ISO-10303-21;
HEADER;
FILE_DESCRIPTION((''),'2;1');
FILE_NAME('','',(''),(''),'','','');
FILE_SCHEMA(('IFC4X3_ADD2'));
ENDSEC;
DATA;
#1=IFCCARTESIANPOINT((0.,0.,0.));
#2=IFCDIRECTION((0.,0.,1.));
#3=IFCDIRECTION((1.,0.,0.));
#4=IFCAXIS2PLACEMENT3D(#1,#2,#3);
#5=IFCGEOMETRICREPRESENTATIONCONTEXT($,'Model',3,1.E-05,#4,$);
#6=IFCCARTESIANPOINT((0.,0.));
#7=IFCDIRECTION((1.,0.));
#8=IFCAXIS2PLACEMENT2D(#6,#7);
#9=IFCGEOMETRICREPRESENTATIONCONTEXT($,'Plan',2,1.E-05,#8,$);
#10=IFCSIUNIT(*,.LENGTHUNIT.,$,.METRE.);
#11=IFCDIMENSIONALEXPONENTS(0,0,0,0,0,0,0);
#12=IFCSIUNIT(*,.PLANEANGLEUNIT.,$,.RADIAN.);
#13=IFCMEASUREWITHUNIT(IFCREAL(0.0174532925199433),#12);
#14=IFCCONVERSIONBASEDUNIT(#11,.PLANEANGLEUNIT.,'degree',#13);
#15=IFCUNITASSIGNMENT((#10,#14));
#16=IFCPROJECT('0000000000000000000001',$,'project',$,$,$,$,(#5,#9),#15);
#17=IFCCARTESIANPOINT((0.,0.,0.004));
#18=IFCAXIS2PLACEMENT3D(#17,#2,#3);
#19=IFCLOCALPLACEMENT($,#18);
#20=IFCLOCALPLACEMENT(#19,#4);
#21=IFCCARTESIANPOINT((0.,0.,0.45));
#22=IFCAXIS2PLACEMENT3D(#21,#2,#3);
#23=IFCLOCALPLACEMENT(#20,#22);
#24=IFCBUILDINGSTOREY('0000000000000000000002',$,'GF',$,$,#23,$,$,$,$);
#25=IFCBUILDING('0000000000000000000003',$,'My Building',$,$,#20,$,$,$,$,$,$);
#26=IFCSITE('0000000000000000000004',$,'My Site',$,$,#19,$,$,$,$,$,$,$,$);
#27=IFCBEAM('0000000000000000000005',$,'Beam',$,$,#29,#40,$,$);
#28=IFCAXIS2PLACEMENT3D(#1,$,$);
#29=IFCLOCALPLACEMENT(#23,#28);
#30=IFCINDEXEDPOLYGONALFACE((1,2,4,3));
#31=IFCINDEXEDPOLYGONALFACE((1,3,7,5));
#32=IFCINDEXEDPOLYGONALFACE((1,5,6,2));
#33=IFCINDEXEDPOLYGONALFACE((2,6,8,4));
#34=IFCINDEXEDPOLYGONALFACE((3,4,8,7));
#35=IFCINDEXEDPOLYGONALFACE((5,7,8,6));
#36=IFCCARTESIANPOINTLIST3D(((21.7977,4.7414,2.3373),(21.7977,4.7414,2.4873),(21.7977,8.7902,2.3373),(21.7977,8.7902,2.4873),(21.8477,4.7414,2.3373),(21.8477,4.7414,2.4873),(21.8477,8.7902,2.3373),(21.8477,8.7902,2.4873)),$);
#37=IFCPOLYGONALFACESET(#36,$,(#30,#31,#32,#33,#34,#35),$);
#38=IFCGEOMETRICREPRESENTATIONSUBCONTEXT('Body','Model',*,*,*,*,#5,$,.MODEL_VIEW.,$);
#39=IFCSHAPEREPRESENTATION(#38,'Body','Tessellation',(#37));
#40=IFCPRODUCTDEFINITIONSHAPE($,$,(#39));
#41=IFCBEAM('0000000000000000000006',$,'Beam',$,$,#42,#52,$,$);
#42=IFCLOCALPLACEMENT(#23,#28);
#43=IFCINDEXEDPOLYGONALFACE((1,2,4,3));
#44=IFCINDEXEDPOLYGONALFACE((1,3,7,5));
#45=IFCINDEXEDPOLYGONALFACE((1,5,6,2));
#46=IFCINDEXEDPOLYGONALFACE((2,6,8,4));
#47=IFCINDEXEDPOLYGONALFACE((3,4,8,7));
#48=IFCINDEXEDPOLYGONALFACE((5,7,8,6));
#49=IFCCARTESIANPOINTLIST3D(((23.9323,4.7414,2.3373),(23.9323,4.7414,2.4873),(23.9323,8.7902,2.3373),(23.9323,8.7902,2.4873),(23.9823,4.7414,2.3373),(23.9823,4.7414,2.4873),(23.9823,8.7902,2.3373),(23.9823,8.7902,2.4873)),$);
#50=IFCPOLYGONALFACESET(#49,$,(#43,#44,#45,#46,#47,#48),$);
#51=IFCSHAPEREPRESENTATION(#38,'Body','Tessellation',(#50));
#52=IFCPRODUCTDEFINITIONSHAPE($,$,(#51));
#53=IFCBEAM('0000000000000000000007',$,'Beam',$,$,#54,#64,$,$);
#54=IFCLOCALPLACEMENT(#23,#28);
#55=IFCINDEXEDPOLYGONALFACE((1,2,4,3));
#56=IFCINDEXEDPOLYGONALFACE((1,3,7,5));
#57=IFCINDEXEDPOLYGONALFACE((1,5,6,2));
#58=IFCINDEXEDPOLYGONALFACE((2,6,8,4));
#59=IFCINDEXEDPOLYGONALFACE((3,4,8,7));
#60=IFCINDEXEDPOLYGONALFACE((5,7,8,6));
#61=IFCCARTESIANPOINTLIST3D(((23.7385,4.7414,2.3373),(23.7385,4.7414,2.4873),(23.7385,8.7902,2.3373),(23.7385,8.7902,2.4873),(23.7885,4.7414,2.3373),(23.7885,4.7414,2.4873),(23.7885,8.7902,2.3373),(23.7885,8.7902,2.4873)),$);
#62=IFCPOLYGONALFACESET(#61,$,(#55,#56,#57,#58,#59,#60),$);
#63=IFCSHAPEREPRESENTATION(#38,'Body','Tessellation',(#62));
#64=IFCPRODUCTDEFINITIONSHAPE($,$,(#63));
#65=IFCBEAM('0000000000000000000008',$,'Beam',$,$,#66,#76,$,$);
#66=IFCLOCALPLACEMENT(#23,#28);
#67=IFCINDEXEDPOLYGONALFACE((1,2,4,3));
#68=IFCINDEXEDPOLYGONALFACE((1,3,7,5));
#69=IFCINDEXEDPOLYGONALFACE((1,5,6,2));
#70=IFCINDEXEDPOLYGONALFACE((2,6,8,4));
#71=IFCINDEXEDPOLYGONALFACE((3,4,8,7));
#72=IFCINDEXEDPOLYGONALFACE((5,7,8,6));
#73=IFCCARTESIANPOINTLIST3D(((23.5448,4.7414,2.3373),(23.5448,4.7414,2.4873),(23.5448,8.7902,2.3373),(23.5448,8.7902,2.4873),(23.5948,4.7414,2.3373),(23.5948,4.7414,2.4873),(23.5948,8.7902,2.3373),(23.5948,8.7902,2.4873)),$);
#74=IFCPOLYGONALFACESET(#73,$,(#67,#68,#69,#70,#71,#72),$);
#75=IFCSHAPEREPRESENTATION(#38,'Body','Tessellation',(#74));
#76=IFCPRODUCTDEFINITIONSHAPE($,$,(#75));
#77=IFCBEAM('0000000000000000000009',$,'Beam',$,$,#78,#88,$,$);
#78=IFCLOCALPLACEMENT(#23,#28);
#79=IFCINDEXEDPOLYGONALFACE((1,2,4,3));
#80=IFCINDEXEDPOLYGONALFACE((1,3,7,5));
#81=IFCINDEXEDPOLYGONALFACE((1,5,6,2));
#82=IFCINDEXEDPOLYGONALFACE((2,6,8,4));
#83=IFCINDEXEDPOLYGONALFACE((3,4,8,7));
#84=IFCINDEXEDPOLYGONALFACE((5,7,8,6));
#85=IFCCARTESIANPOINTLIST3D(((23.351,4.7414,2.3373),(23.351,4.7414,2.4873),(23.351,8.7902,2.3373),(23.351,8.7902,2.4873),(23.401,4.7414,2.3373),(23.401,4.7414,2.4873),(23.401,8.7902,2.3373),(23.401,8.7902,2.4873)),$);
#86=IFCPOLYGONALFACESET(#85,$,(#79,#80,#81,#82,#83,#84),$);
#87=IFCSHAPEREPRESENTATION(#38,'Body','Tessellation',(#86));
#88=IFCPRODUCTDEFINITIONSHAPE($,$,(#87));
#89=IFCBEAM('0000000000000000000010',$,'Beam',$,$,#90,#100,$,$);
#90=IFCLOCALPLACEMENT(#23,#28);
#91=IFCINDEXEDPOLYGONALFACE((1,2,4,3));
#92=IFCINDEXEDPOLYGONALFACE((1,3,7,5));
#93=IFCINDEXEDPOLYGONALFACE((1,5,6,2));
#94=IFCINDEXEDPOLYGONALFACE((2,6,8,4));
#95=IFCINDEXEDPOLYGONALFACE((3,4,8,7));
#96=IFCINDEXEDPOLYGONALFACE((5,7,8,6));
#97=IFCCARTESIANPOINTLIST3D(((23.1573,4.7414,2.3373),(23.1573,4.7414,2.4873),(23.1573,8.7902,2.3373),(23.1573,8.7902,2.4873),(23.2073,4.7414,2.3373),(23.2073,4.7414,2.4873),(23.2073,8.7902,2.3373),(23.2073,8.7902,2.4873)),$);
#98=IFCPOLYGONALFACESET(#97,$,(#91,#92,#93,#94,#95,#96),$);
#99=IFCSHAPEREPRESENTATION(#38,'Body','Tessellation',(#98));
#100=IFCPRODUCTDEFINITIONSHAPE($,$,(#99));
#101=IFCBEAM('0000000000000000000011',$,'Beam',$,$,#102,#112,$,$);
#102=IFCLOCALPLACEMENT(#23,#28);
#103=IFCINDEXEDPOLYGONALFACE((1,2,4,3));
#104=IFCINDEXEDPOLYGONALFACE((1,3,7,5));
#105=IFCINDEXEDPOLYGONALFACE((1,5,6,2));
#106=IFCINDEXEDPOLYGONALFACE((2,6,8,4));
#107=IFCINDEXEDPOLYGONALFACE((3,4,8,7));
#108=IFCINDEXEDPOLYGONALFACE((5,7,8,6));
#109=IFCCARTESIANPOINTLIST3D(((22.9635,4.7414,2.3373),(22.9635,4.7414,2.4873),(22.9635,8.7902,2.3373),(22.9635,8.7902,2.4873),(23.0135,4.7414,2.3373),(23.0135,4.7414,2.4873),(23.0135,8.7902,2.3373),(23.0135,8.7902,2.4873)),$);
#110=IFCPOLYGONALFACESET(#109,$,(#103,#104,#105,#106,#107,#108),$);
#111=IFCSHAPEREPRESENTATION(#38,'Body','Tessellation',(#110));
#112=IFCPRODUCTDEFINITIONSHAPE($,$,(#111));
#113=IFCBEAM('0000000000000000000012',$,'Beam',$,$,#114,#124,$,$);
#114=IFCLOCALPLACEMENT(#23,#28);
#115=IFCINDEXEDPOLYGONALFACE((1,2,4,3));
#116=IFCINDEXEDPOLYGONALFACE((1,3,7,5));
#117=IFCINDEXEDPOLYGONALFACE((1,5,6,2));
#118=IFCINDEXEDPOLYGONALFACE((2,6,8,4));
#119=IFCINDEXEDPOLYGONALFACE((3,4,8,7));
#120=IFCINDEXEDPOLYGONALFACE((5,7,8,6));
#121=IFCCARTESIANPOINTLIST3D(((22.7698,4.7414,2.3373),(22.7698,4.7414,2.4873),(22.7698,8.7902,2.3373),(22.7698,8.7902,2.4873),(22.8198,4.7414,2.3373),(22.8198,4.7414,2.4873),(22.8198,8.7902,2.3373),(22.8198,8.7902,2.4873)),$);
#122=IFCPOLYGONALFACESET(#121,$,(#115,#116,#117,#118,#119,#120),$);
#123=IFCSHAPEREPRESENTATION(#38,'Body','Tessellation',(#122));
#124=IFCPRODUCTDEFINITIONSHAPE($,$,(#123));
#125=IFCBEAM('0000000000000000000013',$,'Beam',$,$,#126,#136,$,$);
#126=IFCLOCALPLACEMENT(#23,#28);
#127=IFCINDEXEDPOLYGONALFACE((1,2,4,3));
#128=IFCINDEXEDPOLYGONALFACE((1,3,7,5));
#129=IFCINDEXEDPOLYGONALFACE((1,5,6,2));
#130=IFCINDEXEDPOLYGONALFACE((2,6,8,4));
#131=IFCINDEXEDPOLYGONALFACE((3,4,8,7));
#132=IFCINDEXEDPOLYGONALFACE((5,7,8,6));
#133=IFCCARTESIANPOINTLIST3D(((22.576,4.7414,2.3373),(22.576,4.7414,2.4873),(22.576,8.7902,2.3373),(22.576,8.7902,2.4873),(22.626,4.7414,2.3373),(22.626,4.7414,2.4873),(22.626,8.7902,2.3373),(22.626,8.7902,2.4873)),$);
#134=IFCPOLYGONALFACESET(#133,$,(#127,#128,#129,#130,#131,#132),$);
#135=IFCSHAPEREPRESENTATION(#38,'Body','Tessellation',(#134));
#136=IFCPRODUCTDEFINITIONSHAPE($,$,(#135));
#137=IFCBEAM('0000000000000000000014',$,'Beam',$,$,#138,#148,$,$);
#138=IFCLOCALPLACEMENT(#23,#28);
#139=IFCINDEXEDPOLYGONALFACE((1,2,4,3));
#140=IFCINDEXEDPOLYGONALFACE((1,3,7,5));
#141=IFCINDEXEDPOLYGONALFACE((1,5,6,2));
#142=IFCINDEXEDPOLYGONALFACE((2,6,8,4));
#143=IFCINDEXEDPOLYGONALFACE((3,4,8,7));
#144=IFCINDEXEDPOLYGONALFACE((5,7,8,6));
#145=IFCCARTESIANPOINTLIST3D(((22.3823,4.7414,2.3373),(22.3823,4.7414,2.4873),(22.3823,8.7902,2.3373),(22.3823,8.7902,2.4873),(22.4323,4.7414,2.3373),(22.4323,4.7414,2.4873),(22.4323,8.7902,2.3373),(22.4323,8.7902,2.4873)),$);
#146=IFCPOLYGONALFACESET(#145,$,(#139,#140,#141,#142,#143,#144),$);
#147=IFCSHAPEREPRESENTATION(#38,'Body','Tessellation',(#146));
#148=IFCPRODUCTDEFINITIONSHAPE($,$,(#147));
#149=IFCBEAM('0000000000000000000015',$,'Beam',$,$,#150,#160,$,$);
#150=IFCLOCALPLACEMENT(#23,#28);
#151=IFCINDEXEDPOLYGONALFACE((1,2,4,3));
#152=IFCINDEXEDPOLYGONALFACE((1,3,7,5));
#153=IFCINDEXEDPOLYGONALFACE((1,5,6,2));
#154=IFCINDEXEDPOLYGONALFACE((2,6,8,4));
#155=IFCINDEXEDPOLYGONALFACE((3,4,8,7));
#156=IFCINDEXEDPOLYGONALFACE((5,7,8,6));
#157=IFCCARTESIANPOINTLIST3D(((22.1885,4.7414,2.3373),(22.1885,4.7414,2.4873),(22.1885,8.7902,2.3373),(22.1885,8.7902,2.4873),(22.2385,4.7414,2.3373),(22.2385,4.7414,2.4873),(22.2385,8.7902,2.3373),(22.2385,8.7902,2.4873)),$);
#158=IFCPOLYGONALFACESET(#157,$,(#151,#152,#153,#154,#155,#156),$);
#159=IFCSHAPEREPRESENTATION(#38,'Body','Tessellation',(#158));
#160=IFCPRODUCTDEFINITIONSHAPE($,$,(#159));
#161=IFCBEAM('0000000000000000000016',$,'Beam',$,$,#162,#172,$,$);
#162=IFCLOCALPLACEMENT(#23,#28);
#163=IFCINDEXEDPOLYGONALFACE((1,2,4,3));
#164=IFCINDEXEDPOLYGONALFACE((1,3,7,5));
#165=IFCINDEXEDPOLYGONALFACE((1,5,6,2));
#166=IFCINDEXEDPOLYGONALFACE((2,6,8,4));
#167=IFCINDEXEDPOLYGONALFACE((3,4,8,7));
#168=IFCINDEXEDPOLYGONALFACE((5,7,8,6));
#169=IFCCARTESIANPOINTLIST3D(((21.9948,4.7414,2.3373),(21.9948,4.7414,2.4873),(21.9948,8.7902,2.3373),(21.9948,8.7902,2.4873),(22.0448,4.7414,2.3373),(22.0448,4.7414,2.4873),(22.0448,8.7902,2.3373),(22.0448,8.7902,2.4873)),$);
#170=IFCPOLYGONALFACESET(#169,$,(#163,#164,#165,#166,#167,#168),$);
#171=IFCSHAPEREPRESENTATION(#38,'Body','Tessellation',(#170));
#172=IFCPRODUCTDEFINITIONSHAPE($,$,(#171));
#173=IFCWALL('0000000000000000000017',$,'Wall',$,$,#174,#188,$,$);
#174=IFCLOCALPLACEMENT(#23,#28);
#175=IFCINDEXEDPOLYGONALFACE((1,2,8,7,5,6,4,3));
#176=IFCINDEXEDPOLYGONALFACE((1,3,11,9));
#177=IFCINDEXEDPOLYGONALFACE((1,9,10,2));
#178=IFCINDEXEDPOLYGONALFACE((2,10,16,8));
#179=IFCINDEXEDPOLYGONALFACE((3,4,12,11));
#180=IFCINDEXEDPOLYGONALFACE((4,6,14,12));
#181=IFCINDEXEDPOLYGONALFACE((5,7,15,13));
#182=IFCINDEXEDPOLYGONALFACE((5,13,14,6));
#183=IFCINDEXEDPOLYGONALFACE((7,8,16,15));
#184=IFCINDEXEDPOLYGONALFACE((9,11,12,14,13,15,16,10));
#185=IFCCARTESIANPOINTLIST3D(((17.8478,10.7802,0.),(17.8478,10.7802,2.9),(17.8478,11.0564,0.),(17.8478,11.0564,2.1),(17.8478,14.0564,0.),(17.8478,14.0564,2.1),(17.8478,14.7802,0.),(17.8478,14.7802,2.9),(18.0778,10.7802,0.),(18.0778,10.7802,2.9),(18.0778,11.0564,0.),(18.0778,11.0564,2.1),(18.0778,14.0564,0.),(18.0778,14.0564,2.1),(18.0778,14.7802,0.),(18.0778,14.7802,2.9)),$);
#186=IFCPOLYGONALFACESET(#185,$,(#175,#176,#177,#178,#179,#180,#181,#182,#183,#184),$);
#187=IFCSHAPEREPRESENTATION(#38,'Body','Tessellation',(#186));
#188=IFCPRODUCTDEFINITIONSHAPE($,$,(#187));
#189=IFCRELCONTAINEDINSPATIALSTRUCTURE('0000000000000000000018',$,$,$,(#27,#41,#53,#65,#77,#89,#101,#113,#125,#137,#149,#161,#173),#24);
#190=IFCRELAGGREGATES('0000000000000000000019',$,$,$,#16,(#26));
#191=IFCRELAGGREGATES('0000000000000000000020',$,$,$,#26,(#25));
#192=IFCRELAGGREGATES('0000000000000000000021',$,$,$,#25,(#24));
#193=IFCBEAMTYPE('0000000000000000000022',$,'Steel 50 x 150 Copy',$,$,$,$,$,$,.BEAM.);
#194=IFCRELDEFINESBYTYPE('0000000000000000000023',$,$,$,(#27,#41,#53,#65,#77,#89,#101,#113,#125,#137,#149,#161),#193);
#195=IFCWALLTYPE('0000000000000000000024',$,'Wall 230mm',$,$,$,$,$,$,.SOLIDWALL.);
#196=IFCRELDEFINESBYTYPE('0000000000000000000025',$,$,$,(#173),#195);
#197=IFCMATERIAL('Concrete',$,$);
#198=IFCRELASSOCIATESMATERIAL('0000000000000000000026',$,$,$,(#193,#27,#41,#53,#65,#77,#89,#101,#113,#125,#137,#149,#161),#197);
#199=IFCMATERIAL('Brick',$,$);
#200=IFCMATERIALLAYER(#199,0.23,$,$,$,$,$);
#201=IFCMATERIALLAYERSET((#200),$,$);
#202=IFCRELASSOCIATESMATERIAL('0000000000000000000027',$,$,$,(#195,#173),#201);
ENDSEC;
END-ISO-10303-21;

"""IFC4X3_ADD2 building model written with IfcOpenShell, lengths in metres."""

from ifc_helpers import new_model, entity, si_unit, converted_unit, frame, origin_with_axes, origin_2d_with_axis, place, context, subcontext, project, spatial, line, indexed_curve, rectangle, outline, extrude, source, transform, mapped, material, layer, layer_set, layer_usage, material_profile, profile_set, profile_usage, type_object, element, save


model = new_model("IFC4X3_ADD2")

# Units and contexts
model_context = context("Model", 3, precision=1e-05, world=origin_with_axes())
plan_context = context("Plan", 2, precision=1e-05, world=origin_2d_with_axis())
body_context = subcontext(model_context, "Body", "Model", "MODEL_VIEW")
ifc_project = project(units=[si_unit("LENGTHUNIT", "METRE"), converted_unit("PLANEANGLEUNIT", "degree", entity("IfcReal", 0.0174532925199433), si_unit("PLANEANGLEUNIT", "RADIAN"), dimensions=[0, 0, 0, 0, 0, 0, 0])], contexts=[model_context, plan_context])

# Site, building, storey
site_placement = place(None, frame((0.0, 0.0, 0.004), z_axis=(0.0, 0.0, 1.0), x_axis=(1.0, 0.0, 0.0)))
site = spatial("IfcSite", under=ifc_project, at=site_placement, Name="My Site")
building_placement = place(site_placement, origin_with_axes())
building = spatial("IfcBuilding", under=site, at=building_placement, Name="My Building")
storey_placement = place(building_placement, frame((0.0, 0.0, 0.45), z_axis=(0.0, 0.0, 1.0), x_axis=(1.0, 0.0, 0.0)))
storey = spatial("IfcBuildingStorey", under=building, at=storey_placement, Name="GF")

# Beams
ifc_material_1 = material(Name="Concrete")
ifc_material_profile = material_profile(ifc_material_1, rectangle(XDim=0.05, YDim=0.15))
ifc_profile_set = profile_set([ifc_material_profile])
ifc_profile_usage_1 = profile_usage(ifc_profile_set)
beam_type = type_object("IfcBeamType", Name="Steel 50 x 150 Copy", PredefinedType="BEAM", material=ifc_profile_set)
beam_1_placement = place(storey_placement, frame((21.8227, 8.7902, 2.4123), z_axis=(0.0, -1.0, 0.0), x_axis=(1.0, 0.0, 0.0)))
element("IfcBeam", 1, at=beam_1_placement, inside=storey, type_object=beam_type, material=ifc_profile_usage_1, Name="Beam", context=body_context, shape_type="SweptSolid", body=[
    extrude(rectangle(XDim=0.05, YDim=0.15), origin_with_axes(), (0.0, 0.0, 1.0), 4.0488),
])
ifc_profile_usage_2 = profile_usage(ifc_profile_set)
beam_2_placement = place(storey_placement, frame((23.9573, 8.7902, 2.4123), z_axis=(0.0, -1.0, 0.0), x_axis=(1.0, 0.0, 0.0)))
element("IfcBeam", 2, at=beam_2_placement, inside=storey, type_object=beam_type, material=ifc_profile_usage_2, Name="Beam", context=body_context, shape_type="SweptSolid", body=[
    extrude(rectangle(XDim=0.05, YDim=0.15), origin_with_axes(), (0.0, 0.0, 1.0), 4.0488),
])
ifc_profile_usage_3 = profile_usage(ifc_profile_set)
beam_3_placement = place(storey_placement, frame((23.7635, 8.7902, 2.4123), z_axis=(0.0, -1.0, 0.0), x_axis=(1.0, 0.0, 0.0)))
element("IfcBeam", 3, at=beam_3_placement, inside=storey, type_object=beam_type, material=ifc_profile_usage_3, Name="Beam", context=body_context, shape_type="SweptSolid", body=[
    extrude(rectangle(XDim=0.05, YDim=0.15), origin_with_axes(), (0.0, 0.0, 1.0), 4.0488),
])
ifc_profile_usage_4 = profile_usage(ifc_profile_set)
beam_4_placement = place(storey_placement, frame((23.5698, 8.7902, 2.4123), z_axis=(0.0, -1.0, 0.0), x_axis=(1.0, 0.0, 0.0)))
element("IfcBeam", 4, at=beam_4_placement, inside=storey, type_object=beam_type, material=ifc_profile_usage_4, Name="Beam", context=body_context, shape_type="SweptSolid", body=[
    extrude(rectangle(XDim=0.05, YDim=0.15), origin_with_axes(), (0.0, 0.0, 1.0), 4.0488),
])
ifc_profile_usage_5 = profile_usage(ifc_profile_set)
beam_5_placement = place(storey_placement, frame((23.376, 8.7902, 2.4123), z_axis=(0.0, -1.0, 0.0), x_axis=(1.0, 0.0, 0.0)))
element("IfcBeam", 5, at=beam_5_placement, inside=storey, type_object=beam_type, material=ifc_profile_usage_5, Name="Beam", context=body_context, shape_type="SweptSolid", body=[
    extrude(rectangle(XDim=0.05, YDim=0.15), origin_with_axes(), (0.0, 0.0, 1.0), 4.0488),
])
ifc_profile_usage_6 = profile_usage(ifc_profile_set)
beam_6_placement = place(storey_placement, frame((23.1823, 8.7902, 2.4123), z_axis=(0.0, -1.0, 0.0), x_axis=(1.0, 0.0, 0.0)))
element("IfcBeam", 6, at=beam_6_placement, inside=storey, type_object=beam_type, material=ifc_profile_usage_6, Name="Beam", context=body_context, shape_type="SweptSolid", body=[
    extrude(rectangle(XDim=0.05, YDim=0.15), origin_with_axes(), (0.0, 0.0, 1.0), 4.0488),
])
ifc_profile_usage_7 = profile_usage(ifc_profile_set)
beam_7_placement = place(storey_placement, frame((22.9885, 8.7902, 2.4123), z_axis=(0.0, -1.0, 0.0), x_axis=(1.0, 0.0, 0.0)))
element("IfcBeam", 7, at=beam_7_placement, inside=storey, type_object=beam_type, material=ifc_profile_usage_7, Name="Beam", context=body_context, shape_type="SweptSolid", body=[
    extrude(rectangle(XDim=0.05, YDim=0.15), origin_with_axes(), (0.0, 0.0, 1.0), 4.0488),
])
ifc_profile_usage_8 = profile_usage(ifc_profile_set)
beam_8_placement = place(storey_placement, frame((22.7948, 8.7902, 2.4123), z_axis=(0.0, -1.0, 0.0), x_axis=(1.0, 0.0, 0.0)))
element("IfcBeam", 8, at=beam_8_placement, inside=storey, type_object=beam_type, material=ifc_profile_usage_8, Name="Beam", context=body_context, shape_type="SweptSolid", body=[
    extrude(rectangle(XDim=0.05, YDim=0.15), origin_with_axes(), (0.0, 0.0, 1.0), 4.0488),
])
ifc_profile_usage_9 = profile_usage(ifc_profile_set)
beam_9_placement = place(storey_placement, frame((22.601, 8.7902, 2.4123), z_axis=(0.0, -1.0, 0.0), x_axis=(1.0, 0.0, 0.0)))
element("IfcBeam", 9, at=beam_9_placement, inside=storey, type_object=beam_type, material=ifc_profile_usage_9, Name="Beam", context=body_context, shape_type="SweptSolid", body=[
    extrude(rectangle(XDim=0.05, YDim=0.15), origin_with_axes(), (0.0, 0.0, 1.0), 4.0488),
])
ifc_profile_usage_10 = profile_usage(ifc_profile_set)
beam_10_placement = place(storey_placement, frame((22.4073, 8.7902, 2.4123), z_axis=(0.0, -1.0, 0.0), x_axis=(1.0, 0.0, 0.0)))
element("IfcBeam", 10, at=beam_10_placement, inside=storey, type_object=beam_type, material=ifc_profile_usage_10, Name="Beam", context=body_context, shape_type="SweptSolid", body=[
    extrude(rectangle(XDim=0.05, YDim=0.15), origin_with_axes(), (0.0, 0.0, 1.0), 4.0488),
])
ifc_profile_usage_11 = profile_usage(ifc_profile_set)
beam_11_placement = place(storey_placement, frame((22.2135, 8.7902, 2.4123), z_axis=(0.0, -1.0, 0.0), x_axis=(1.0, 0.0, 0.0)))
element("IfcBeam", 11, at=beam_11_placement, inside=storey, type_object=beam_type, material=ifc_profile_usage_11, Name="Beam", context=body_context, shape_type="SweptSolid", body=[
    extrude(rectangle(XDim=0.05, YDim=0.15), origin_with_axes(), (0.0, 0.0, 1.0), 4.0488),
])
ifc_profile_usage_12 = profile_usage(ifc_profile_set)
beam_12_placement = place(storey_placement, frame((22.0198, 8.7902, 2.4123), z_axis=(0.0, -1.0, 0.0), x_axis=(1.0, 0.0, 0.0)))
element("IfcBeam", 12, at=beam_12_placement, inside=storey, type_object=beam_type, material=ifc_profile_usage_12, Name="Beam", context=body_context, shape_type="SweptSolid", body=[
    extrude(rectangle(XDim=0.05, YDim=0.15), origin_with_axes(), (0.0, 0.0, 1.0), 4.0488),
])

# Wall, opening
ifc_material_2 = material(Name="Brick")
ifc_layer = layer(ifc_material_2, 0.23)
ifc_layer_set = layer_set([ifc_layer])
ifc_layer_usage_1 = layer_usage(ifc_layer_set, "AXIS2", "POSITIVE", 0.0)
wall_type = type_object("IfcWallType", Name="Wall 230mm", PredefinedType="SOLIDWALL", material=ifc_layer_set)
wall_1_placement = place(storey_placement, frame((18.0778, 10.7802, 0.0), z_axis=(0.0, 0.0, 1.0), x_axis=(0.000001, 1.0, 0.0)))
wall_1 = element("IfcWall", 13, at=wall_1_placement, inside=storey, type_object=wall_type, material=ifc_layer_usage_1, Name="Wall", context=body_context, shape_type="SweptSolid", body=[
    extrude(outline(indexed_curve([(0.0, 0.0), (0.0, 0.23), (4.0, 0.23), (4.0, 0.0), (0.0, 0.0)], self_intersect=False)), origin_with_axes(), (0.0, 0.0, 1.0), 2.9),
])
shared_shape = source(origin_with_axes(), body_context, "Body", "SweptSolid", [
    extrude(outline(indexed_curve([(0.0, 0.0), (3.0, 0.0), (3.0, 2.1), (0.0, 2.1)], segments=[line(1, 2, 3, 4, 1)])), frame((0.0, -0.6, 0.0), z_axis=(0.0, -1.0, 0.0), x_axis=(1.0, 0.0, 0.0)), (0.0, 0.0, -1.0), 1.2),
])
opening_1_placement = place(wall_1_placement, frame((0.2763, 0.0, 0.0), z_axis=(0.0, 0.0, 1.0), x_axis=(1.0, 0.0, 0.0)))
element("IfcOpeningElement", 14, at=opening_1_placement, cuts=wall_1, PredefinedType="OPENING", context=body_context, shape_type="MappedRepresentation", body=[
    mapped(shared_shape, transform((0.0, 0.0, 0.0), x_axis=(1.0, 0.0, 0.0), y_axis=(0.0, 1.0, 0.0), z_axis=(0.0, 0.0, 1.0), scale=1.0)),
])

save(model, "model.ifc")
